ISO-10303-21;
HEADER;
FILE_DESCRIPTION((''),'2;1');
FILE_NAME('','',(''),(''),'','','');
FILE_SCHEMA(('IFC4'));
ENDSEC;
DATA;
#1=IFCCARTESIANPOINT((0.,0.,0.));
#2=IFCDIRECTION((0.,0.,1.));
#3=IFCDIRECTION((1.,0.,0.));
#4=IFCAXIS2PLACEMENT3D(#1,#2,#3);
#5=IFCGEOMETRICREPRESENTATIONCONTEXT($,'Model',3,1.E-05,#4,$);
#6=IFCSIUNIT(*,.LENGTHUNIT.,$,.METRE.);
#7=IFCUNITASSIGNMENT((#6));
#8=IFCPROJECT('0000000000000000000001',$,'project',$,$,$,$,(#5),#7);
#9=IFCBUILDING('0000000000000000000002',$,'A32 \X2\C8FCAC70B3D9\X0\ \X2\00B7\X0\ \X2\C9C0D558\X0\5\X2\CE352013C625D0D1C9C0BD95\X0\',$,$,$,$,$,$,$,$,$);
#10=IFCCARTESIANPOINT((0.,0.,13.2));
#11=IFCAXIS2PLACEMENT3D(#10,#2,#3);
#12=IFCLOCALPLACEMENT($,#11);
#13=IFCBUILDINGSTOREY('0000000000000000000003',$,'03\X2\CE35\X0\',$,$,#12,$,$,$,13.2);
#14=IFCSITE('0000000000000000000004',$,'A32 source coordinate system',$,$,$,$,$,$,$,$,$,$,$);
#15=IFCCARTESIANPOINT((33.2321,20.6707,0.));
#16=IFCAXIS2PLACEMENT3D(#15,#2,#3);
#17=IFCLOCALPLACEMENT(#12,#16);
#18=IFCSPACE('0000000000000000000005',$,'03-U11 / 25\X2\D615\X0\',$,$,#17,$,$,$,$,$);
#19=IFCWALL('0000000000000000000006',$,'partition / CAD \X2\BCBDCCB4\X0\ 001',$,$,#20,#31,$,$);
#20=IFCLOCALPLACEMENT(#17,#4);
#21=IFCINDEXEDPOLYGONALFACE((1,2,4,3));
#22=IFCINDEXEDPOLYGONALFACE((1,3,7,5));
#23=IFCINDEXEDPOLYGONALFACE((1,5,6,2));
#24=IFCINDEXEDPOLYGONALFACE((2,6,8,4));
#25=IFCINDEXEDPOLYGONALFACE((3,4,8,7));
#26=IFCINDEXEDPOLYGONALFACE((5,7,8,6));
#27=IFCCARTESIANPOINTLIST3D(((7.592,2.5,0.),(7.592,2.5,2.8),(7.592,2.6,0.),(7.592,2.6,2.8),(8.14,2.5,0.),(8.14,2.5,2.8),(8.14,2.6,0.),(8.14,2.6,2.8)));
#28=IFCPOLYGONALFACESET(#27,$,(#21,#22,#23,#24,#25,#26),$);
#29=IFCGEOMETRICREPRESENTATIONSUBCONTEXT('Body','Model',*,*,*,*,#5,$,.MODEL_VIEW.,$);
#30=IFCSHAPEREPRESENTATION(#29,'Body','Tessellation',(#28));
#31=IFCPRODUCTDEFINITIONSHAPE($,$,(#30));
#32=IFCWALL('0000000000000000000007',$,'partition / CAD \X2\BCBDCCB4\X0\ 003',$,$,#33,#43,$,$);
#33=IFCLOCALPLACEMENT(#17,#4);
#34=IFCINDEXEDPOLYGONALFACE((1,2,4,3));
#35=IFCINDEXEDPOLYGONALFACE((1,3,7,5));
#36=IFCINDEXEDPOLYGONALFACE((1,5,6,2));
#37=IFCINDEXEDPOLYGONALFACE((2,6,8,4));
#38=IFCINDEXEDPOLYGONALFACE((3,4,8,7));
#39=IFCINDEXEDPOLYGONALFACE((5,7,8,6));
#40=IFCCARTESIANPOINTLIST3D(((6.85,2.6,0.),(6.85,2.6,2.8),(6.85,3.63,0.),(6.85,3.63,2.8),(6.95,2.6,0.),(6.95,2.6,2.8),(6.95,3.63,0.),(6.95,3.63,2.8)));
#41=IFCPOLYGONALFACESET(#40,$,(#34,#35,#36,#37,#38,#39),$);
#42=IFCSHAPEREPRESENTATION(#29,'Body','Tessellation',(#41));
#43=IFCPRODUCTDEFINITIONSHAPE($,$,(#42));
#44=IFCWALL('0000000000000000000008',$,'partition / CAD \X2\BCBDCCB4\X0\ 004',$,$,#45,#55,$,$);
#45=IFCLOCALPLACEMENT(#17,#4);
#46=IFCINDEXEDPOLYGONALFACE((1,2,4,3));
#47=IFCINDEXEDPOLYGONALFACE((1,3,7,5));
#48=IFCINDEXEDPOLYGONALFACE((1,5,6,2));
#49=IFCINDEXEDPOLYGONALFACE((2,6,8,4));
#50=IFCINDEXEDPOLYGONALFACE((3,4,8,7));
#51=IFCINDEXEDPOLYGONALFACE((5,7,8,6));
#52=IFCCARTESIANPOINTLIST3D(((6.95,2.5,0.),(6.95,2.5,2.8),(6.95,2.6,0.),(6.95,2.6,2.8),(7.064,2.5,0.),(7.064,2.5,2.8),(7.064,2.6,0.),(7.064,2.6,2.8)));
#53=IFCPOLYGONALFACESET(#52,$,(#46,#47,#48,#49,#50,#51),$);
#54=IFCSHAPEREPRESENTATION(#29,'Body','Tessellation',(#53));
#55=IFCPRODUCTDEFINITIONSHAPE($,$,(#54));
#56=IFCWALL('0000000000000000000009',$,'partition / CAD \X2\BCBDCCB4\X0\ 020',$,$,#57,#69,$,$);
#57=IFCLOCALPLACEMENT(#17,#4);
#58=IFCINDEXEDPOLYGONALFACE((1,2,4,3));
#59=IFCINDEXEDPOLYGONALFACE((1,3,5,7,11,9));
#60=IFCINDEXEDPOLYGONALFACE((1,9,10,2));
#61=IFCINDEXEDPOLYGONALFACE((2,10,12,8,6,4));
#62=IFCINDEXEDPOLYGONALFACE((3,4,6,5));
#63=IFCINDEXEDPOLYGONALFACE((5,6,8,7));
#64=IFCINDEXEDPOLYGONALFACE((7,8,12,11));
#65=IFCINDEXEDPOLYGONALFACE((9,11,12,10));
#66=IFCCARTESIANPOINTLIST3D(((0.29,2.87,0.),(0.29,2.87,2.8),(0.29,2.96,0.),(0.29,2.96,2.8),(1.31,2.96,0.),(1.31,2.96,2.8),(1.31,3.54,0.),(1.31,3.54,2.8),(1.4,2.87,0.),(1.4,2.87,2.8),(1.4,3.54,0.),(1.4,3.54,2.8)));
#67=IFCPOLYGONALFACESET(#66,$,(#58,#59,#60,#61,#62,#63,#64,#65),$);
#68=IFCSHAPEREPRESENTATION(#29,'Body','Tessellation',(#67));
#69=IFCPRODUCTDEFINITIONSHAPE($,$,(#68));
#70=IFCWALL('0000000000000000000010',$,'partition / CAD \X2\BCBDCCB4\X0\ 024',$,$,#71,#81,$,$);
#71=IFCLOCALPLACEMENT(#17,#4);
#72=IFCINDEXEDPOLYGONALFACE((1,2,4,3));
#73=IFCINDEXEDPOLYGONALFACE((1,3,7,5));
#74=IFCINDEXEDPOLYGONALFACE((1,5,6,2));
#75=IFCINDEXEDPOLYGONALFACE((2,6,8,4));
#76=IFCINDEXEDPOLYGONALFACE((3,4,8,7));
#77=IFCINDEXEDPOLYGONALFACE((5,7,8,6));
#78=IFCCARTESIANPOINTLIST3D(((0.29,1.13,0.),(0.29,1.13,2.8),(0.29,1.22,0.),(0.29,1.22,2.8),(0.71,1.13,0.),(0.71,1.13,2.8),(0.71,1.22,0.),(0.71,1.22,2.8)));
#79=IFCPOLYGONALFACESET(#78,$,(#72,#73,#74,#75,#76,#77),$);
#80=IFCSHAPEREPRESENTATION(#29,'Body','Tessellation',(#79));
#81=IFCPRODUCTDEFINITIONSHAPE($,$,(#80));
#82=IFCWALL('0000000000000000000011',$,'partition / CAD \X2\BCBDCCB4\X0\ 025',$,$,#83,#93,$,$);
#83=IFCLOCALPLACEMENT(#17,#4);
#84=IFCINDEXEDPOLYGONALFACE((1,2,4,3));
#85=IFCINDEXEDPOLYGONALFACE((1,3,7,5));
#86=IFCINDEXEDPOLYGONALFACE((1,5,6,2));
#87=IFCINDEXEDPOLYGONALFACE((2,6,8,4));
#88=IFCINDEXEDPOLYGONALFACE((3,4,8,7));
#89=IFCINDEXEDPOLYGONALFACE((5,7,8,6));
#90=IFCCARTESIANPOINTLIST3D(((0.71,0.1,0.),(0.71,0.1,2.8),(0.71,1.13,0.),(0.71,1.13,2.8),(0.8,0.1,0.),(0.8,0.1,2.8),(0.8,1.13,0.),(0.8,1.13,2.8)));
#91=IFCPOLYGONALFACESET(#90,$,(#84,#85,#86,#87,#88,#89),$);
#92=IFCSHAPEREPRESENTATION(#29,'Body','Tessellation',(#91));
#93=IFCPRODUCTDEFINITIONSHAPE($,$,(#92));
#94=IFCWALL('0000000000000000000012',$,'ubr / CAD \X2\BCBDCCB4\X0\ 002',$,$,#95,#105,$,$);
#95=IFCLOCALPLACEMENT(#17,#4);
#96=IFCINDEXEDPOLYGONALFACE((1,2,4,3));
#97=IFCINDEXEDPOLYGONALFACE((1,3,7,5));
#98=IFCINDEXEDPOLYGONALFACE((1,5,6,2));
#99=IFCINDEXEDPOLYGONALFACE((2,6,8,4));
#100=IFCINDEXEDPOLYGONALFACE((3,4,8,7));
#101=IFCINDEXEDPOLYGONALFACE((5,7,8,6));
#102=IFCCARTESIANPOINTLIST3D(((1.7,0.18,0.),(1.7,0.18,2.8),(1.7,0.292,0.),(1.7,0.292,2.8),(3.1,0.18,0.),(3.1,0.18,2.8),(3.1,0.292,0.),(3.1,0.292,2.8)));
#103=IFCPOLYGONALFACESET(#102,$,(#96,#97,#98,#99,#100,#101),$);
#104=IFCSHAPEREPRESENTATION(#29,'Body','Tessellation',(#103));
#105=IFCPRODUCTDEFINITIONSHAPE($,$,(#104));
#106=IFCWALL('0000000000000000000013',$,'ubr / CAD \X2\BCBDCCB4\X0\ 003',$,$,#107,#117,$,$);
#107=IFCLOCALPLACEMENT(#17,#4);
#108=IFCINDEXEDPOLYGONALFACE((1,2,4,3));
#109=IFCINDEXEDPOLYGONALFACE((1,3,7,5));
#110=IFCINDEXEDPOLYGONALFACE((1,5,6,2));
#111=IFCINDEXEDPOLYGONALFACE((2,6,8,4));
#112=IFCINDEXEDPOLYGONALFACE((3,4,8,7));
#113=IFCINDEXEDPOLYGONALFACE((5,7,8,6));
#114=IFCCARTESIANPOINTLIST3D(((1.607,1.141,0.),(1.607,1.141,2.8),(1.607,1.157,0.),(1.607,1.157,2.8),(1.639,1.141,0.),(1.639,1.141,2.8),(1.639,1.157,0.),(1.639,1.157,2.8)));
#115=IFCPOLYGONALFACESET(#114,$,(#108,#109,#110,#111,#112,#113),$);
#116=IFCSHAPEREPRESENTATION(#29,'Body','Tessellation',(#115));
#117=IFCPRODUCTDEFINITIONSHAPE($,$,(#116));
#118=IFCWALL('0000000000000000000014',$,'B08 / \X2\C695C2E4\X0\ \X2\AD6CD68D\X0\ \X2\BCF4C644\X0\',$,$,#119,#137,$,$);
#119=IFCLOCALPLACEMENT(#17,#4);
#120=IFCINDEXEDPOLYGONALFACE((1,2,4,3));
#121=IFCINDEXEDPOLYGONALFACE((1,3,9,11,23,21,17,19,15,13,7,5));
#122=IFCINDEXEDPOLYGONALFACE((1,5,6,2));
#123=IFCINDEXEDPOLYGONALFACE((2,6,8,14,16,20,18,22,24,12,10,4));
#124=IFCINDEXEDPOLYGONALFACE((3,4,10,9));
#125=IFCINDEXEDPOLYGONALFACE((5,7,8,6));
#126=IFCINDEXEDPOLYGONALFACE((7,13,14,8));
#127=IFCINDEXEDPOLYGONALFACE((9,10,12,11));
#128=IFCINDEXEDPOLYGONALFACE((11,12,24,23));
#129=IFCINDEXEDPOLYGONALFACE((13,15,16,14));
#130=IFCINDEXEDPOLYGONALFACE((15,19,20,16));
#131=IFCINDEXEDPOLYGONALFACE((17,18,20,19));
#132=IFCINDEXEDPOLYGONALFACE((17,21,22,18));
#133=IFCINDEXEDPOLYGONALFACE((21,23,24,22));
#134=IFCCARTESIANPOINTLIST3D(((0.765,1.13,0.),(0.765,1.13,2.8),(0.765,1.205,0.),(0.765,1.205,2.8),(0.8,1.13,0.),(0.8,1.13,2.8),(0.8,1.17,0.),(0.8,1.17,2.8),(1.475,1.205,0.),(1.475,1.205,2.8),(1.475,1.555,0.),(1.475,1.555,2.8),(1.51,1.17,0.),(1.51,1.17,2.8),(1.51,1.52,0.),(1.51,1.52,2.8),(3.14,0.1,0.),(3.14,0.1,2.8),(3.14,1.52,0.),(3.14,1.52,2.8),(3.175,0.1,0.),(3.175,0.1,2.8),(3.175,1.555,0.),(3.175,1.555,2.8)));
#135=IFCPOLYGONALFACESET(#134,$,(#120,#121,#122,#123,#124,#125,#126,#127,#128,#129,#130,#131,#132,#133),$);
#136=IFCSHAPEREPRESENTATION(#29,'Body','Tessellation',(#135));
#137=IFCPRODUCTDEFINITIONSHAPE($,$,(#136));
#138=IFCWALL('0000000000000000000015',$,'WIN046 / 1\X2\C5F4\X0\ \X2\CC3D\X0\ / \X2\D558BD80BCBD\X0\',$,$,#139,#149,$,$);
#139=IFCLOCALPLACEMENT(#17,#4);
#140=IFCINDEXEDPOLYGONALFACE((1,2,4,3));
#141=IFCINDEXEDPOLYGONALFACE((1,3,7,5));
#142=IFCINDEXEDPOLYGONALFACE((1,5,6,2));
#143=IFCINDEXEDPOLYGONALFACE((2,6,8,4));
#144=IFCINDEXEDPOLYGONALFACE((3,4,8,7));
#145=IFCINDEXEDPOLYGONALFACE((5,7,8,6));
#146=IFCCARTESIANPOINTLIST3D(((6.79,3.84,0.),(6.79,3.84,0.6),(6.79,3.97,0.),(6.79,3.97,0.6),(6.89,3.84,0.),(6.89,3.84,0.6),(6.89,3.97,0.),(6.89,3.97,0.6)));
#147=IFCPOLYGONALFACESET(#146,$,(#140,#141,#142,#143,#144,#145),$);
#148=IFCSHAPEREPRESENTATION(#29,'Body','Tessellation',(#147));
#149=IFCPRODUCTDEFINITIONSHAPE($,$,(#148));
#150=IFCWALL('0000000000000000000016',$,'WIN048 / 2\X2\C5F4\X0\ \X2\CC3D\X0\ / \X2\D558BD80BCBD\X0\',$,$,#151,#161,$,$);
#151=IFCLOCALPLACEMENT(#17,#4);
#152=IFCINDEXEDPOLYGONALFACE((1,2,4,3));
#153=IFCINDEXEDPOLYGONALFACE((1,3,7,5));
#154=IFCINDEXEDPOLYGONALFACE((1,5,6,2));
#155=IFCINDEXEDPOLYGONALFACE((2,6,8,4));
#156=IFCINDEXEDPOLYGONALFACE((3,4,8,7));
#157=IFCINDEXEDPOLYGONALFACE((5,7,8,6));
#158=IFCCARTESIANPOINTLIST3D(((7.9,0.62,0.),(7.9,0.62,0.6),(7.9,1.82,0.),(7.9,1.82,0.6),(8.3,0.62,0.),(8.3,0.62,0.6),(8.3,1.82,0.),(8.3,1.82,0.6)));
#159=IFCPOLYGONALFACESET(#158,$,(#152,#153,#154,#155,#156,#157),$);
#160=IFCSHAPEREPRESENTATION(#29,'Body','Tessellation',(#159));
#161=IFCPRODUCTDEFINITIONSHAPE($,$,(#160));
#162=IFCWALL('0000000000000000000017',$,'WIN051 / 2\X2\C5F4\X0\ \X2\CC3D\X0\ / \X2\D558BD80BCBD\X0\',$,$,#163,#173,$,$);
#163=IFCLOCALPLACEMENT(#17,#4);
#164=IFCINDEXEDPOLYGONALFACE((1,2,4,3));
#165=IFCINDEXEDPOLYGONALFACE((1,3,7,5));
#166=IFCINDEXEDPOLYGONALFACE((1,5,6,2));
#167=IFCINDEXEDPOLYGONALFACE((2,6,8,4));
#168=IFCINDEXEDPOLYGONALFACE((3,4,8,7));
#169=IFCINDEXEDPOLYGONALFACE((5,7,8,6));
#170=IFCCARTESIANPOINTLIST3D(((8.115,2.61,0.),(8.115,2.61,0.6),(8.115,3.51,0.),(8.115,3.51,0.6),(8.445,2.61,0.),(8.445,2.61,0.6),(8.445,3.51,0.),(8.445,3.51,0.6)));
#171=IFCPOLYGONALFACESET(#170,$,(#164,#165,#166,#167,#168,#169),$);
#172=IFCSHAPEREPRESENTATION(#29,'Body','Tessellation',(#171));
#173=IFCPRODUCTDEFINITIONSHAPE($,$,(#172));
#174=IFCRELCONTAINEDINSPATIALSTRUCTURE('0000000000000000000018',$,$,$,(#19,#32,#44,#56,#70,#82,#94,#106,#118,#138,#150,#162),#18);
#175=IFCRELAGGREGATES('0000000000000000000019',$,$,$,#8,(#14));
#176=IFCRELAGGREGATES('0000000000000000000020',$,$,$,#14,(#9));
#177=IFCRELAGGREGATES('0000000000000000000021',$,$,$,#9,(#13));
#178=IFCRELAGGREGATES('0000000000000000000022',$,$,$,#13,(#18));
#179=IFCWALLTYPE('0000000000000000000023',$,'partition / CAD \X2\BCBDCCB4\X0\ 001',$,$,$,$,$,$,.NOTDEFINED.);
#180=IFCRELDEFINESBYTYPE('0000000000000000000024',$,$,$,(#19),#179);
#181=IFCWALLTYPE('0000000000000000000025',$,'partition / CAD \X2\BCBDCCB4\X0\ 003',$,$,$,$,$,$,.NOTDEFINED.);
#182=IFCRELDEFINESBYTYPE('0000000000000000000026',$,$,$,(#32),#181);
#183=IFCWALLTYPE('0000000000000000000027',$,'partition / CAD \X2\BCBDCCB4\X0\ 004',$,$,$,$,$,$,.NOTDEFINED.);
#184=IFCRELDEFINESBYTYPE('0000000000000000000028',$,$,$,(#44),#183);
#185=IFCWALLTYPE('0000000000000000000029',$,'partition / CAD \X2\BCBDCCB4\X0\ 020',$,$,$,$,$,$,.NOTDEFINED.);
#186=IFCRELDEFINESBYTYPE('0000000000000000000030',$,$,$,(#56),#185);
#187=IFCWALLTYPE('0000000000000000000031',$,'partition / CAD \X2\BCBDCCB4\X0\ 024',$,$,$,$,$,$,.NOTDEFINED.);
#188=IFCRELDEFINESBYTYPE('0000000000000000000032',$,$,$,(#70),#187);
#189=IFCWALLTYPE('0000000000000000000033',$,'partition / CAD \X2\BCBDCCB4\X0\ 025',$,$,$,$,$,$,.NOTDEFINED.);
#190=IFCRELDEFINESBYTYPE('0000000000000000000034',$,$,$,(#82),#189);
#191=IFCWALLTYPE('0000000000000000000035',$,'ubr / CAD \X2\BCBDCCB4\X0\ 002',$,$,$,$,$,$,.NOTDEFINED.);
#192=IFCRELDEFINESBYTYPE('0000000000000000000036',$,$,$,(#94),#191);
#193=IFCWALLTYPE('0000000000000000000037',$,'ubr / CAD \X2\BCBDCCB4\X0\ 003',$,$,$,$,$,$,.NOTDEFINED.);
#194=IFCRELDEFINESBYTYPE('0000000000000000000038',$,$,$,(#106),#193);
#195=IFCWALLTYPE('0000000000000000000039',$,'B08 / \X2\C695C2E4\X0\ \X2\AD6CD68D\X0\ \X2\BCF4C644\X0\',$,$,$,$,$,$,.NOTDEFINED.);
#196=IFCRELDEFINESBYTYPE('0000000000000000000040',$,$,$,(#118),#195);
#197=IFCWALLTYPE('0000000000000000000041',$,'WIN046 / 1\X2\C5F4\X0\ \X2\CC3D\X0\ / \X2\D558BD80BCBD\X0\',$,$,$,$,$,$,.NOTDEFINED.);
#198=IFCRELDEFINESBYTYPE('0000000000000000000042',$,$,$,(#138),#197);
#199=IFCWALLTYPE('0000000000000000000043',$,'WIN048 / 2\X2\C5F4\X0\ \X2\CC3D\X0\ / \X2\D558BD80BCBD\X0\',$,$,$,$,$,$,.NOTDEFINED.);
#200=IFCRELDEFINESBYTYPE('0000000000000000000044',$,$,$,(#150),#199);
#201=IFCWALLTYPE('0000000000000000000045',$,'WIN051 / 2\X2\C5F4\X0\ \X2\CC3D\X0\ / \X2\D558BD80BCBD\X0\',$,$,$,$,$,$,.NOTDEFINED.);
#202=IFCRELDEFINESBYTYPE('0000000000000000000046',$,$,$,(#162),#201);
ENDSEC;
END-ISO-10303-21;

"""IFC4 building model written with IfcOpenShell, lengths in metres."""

from ifc_helpers import new_model, si_unit, frame, origin, origin_with_axes, place, context, subcontext, project, spatial, polyline, outline, extrude, source, transform, mapped, type_object, type_shapes, element, save


model = new_model("IFC4")

# Units and contexts
model_context = context("Model", 3, precision=1e-05, world=origin_with_axes())
body_context = subcontext(model_context, "Body", "Model", "MODEL_VIEW")
ifc_project = project(units=[si_unit("LENGTHUNIT", "METRE")], contexts=[model_context])

# Site, building, storey, space
site = spatial("IfcSite", under=ifc_project, Name="A32 source coordinate system")
building = spatial("IfcBuilding", under=site, Name="A32 주거동 · 지하5층–옥탑지붕")
storey_placement = place(None, frame((0.0, 0.0, 13.2), z_axis=(0.0, 0.0, 1.0), x_axis=(1.0, 0.0, 0.0)))
storey = spatial("IfcBuildingStorey", under=building, at=storey_placement, Name="03층", Elevation=13.2)
space_1_placement = place(storey_placement, frame((33.2321, 20.6707, 0.0), z_axis=(0.0, 0.0, 1.0), x_axis=(1.0, 0.0, 0.0)))
space_1 = spatial("IfcSpace", under=storey, at=space_1_placement, Name="03-U11 / 25형")

# Walls
wall_type_1 = type_object("IfcWallType", Name="partition / CAD 벽체 001", PredefinedType="NOTDEFINED")
shared_shape_1 = source(origin(), body_context, "Body", "SweptSolid", [
    extrude(outline(polyline([(8.14, 2.6), (8.14, 2.5), (7.592, 2.5), (7.592, 2.6), (8.14, 2.6)])), origin(), (0.0, 0.0, 1.0), 2.8),
])
type_shapes(wall_type_1, [shared_shape_1])
wall_1_placement = place(space_1_placement, origin_with_axes())
element("IfcWall", 1, at=wall_1_placement, inside=space_1, type_object=wall_type_1, Name="partition / CAD 벽체 001", context=body_context, shape_type="MappedRepresentation", body=[
    mapped(shared_shape_1, transform((0.0, 0.0, 0.0), scale=1.0)),
])
wall_type_2 = type_object("IfcWallType", Name="partition / CAD 벽체 003", PredefinedType="NOTDEFINED")
shared_shape_2 = source(origin(), body_context, "Body", "SweptSolid", [
    extrude(outline(polyline([(6.85, 2.6), (6.85, 3.63), (6.95, 3.63), (6.95, 2.6), (6.85, 2.6)])), origin(), (0.0, 0.0, 1.0), 2.8),
])
type_shapes(wall_type_2, [shared_shape_2])
wall_2_placement = place(space_1_placement, origin_with_axes())
element("IfcWall", 2, at=wall_2_placement, inside=space_1, type_object=wall_type_2, Name="partition / CAD 벽체 003", context=body_context, shape_type="MappedRepresentation", body=[
    mapped(shared_shape_2, transform((0.0, 0.0, 0.0), scale=1.0)),
])
wall_type_3 = type_object("IfcWallType", Name="partition / CAD 벽체 004", PredefinedType="NOTDEFINED")
shared_shape_3 = source(origin(), body_context, "Body", "SweptSolid", [
    extrude(outline(polyline([(6.95, 2.5), (6.95, 2.6), (7.064, 2.6), (7.064, 2.5), (6.95, 2.5)])), origin(), (0.0, 0.0, 1.0), 2.8),
])
type_shapes(wall_type_3, [shared_shape_3])
wall_3_placement = place(space_1_placement, origin_with_axes())
element("IfcWall", 3, at=wall_3_placement, inside=space_1, type_object=wall_type_3, Name="partition / CAD 벽체 004", context=body_context, shape_type="MappedRepresentation", body=[
    mapped(shared_shape_3, transform((0.0, 0.0, 0.0), scale=1.0)),
])
wall_type_4 = type_object("IfcWallType", Name="partition / CAD 벽체 020", PredefinedType="NOTDEFINED")
shared_shape_4 = source(origin(), body_context, "Body", "SweptSolid", [
    extrude(outline(polyline([(0.29, 2.87), (0.29, 2.96), (1.31, 2.96), (1.31, 3.54), (1.4, 3.54), (1.4, 2.87), (0.29, 2.87)])), origin(), (0.0, 0.0, 1.0), 2.8),
])
type_shapes(wall_type_4, [shared_shape_4])
wall_4_placement = place(space_1_placement, origin_with_axes())
element("IfcWall", 4, at=wall_4_placement, inside=space_1, type_object=wall_type_4, Name="partition / CAD 벽체 020", context=body_context, shape_type="MappedRepresentation", body=[
    mapped(shared_shape_4, transform((0.0, 0.0, 0.0), scale=1.0)),
])
wall_type_5 = type_object("IfcWallType", Name="partition / CAD 벽체 024", PredefinedType="NOTDEFINED")
shared_shape_5 = source(origin(), body_context, "Body", "SweptSolid", [
    extrude(outline(polyline([(0.71, 1.13), (0.29, 1.13), (0.29, 1.22), (0.71, 1.22), (0.71, 1.13)])), origin(), (0.0, 0.0, 1.0), 2.8),
])
type_shapes(wall_type_5, [shared_shape_5])
wall_5_placement = place(space_1_placement, origin_with_axes())
element("IfcWall", 5, at=wall_5_placement, inside=space_1, type_object=wall_type_5, Name="partition / CAD 벽체 024", context=body_context, shape_type="MappedRepresentation", body=[
    mapped(shared_shape_5, transform((0.0, 0.0, 0.0), scale=1.0)),
])
wall_type_6 = type_object("IfcWallType", Name="partition / CAD 벽체 025", PredefinedType="NOTDEFINED")
shared_shape_6 = source(origin(), body_context, "Body", "SweptSolid", [
    extrude(outline(polyline([(0.71, 1.13), (0.8, 1.13), (0.8, 0.1), (0.71, 0.1), (0.71, 1.13)])), origin(), (0.0, 0.0, 1.0), 2.8),
])
type_shapes(wall_type_6, [shared_shape_6])
wall_6_placement = place(space_1_placement, origin_with_axes())
element("IfcWall", 6, at=wall_6_placement, inside=space_1, type_object=wall_type_6, Name="partition / CAD 벽체 025", context=body_context, shape_type="MappedRepresentation", body=[
    mapped(shared_shape_6, transform((0.0, 0.0, 0.0), scale=1.0)),
])
wall_type_7 = type_object("IfcWallType", Name="ubr / CAD 벽체 002", PredefinedType="NOTDEFINED")
shared_shape_7 = source(origin(), body_context, "Body", "SweptSolid", [
    extrude(outline(polyline([(3.1, 0.292), (3.1, 0.18), (1.7, 0.18), (1.7, 0.292), (3.1, 0.292)])), origin(), (0.0, 0.0, 1.0), 2.8),
])
type_shapes(wall_type_7, [shared_shape_7])
wall_7_placement = place(space_1_placement, origin_with_axes())
element("IfcWall", 7, at=wall_7_placement, inside=space_1, type_object=wall_type_7, Name="ubr / CAD 벽체 002", context=body_context, shape_type="MappedRepresentation", body=[
    mapped(shared_shape_7, transform((0.0, 0.0, 0.0), scale=1.0)),
])
wall_type_8 = type_object("IfcWallType", Name="ubr / CAD 벽체 003", PredefinedType="NOTDEFINED")
shared_shape_8 = source(origin(), body_context, "Body", "SweptSolid", [
    extrude(outline(polyline([(1.639, 1.157), (1.639, 1.141), (1.607, 1.141), (1.607, 1.157), (1.639, 1.157)])), origin(), (0.0, 0.0, 1.0), 2.8),
])
type_shapes(wall_type_8, [shared_shape_8])
wall_8_placement = place(space_1_placement, origin_with_axes())
element("IfcWall", 8, at=wall_8_placement, inside=space_1, type_object=wall_type_8, Name="ubr / CAD 벽체 003", context=body_context, shape_type="MappedRepresentation", body=[
    mapped(shared_shape_8, transform((0.0, 0.0, 0.0), scale=1.0)),
])
wall_type_9 = type_object("IfcWallType", Name="B08 / 욕실 구획 보완", PredefinedType="NOTDEFINED")
shared_shape_9 = source(origin(), body_context, "Body", "SweptSolid", [
    extrude(outline(polyline([(0.765, 1.205), (1.475, 1.205), (1.475, 1.555), (3.175, 1.555), (3.175, 0.1), (3.14, 0.1), (3.14, 1.52), (1.51, 1.52), (1.51, 1.17), (0.8, 1.17), (0.8, 1.13), (0.765, 1.13), (0.765, 1.205)])), origin(), (0.0, 0.0, 1.0), 2.8),
])
type_shapes(wall_type_9, [shared_shape_9])
wall_9_placement = place(space_1_placement, origin_with_axes())
element("IfcWall", 9, at=wall_9_placement, inside=space_1, type_object=wall_type_9, Name="B08 / 욕실 구획 보완", context=body_context, shape_type="MappedRepresentation", body=[
    mapped(shared_shape_9, transform((0.0, 0.0, 0.0), scale=1.0)),
])
wall_type_10 = type_object("IfcWallType", Name="WIN046 / 1열 창 / 하부벽", PredefinedType="NOTDEFINED")
shared_shape_10 = source(origin(), body_context, "Body", "SweptSolid", [
    extrude(outline(polyline([(6.89, 3.84), (6.79, 3.84), (6.79, 3.97), (6.89, 3.97), (6.89, 3.84)])), origin(), (0.0, 0.0, 1.0), 0.6),
])
type_shapes(wall_type_10, [shared_shape_10])
wall_10_placement = place(space_1_placement, origin_with_axes())
element("IfcWall", 10, at=wall_10_placement, inside=space_1, type_object=wall_type_10, Name="WIN046 / 1열 창 / 하부벽", context=body_context, shape_type="MappedRepresentation", body=[
    mapped(shared_shape_10, transform((0.0, 0.0, 0.0), scale=1.0)),
])
wall_type_11 = type_object("IfcWallType", Name="WIN048 / 2열 창 / 하부벽", PredefinedType="NOTDEFINED")
shared_shape_11 = source(origin(), body_context, "Body", "SweptSolid", [
    extrude(outline(polyline([(8.3, 0.62), (7.9, 0.62), (7.9, 1.82), (8.3, 1.82), (8.3, 0.62)])), origin(), (0.0, 0.0, 1.0), 0.6),
])
type_shapes(wall_type_11, [shared_shape_11])
wall_11_placement = place(space_1_placement, origin_with_axes())
element("IfcWall", 11, at=wall_11_placement, inside=space_1, type_object=wall_type_11, Name="WIN048 / 2열 창 / 하부벽", context=body_context, shape_type="MappedRepresentation", body=[
    mapped(shared_shape_11, transform((0.0, 0.0, 0.0), scale=1.0)),
])
wall_type_12 = type_object("IfcWallType", Name="WIN051 / 2열 창 / 하부벽", PredefinedType="NOTDEFINED")
shared_shape_12 = source(origin(), body_context, "Body", "SweptSolid", [
    extrude(outline(polyline([(8.445, 2.61), (8.115, 2.61), (8.115, 3.51), (8.445, 3.51), (8.445, 2.61)])), origin(), (0.0, 0.0, 1.0), 0.6),
])
type_shapes(wall_type_12, [shared_shape_12])
wall_12_placement = place(space_1_placement, origin_with_axes())
element("IfcWall", 12, at=wall_12_placement, inside=space_1, type_object=wall_type_12, Name="WIN051 / 2열 창 / 하부벽", context=body_context, shape_type="MappedRepresentation", body=[
    mapped(shared_shape_12, transform((0.0, 0.0, 0.0), scale=1.0)),
])

save(model, "model.ifc")
